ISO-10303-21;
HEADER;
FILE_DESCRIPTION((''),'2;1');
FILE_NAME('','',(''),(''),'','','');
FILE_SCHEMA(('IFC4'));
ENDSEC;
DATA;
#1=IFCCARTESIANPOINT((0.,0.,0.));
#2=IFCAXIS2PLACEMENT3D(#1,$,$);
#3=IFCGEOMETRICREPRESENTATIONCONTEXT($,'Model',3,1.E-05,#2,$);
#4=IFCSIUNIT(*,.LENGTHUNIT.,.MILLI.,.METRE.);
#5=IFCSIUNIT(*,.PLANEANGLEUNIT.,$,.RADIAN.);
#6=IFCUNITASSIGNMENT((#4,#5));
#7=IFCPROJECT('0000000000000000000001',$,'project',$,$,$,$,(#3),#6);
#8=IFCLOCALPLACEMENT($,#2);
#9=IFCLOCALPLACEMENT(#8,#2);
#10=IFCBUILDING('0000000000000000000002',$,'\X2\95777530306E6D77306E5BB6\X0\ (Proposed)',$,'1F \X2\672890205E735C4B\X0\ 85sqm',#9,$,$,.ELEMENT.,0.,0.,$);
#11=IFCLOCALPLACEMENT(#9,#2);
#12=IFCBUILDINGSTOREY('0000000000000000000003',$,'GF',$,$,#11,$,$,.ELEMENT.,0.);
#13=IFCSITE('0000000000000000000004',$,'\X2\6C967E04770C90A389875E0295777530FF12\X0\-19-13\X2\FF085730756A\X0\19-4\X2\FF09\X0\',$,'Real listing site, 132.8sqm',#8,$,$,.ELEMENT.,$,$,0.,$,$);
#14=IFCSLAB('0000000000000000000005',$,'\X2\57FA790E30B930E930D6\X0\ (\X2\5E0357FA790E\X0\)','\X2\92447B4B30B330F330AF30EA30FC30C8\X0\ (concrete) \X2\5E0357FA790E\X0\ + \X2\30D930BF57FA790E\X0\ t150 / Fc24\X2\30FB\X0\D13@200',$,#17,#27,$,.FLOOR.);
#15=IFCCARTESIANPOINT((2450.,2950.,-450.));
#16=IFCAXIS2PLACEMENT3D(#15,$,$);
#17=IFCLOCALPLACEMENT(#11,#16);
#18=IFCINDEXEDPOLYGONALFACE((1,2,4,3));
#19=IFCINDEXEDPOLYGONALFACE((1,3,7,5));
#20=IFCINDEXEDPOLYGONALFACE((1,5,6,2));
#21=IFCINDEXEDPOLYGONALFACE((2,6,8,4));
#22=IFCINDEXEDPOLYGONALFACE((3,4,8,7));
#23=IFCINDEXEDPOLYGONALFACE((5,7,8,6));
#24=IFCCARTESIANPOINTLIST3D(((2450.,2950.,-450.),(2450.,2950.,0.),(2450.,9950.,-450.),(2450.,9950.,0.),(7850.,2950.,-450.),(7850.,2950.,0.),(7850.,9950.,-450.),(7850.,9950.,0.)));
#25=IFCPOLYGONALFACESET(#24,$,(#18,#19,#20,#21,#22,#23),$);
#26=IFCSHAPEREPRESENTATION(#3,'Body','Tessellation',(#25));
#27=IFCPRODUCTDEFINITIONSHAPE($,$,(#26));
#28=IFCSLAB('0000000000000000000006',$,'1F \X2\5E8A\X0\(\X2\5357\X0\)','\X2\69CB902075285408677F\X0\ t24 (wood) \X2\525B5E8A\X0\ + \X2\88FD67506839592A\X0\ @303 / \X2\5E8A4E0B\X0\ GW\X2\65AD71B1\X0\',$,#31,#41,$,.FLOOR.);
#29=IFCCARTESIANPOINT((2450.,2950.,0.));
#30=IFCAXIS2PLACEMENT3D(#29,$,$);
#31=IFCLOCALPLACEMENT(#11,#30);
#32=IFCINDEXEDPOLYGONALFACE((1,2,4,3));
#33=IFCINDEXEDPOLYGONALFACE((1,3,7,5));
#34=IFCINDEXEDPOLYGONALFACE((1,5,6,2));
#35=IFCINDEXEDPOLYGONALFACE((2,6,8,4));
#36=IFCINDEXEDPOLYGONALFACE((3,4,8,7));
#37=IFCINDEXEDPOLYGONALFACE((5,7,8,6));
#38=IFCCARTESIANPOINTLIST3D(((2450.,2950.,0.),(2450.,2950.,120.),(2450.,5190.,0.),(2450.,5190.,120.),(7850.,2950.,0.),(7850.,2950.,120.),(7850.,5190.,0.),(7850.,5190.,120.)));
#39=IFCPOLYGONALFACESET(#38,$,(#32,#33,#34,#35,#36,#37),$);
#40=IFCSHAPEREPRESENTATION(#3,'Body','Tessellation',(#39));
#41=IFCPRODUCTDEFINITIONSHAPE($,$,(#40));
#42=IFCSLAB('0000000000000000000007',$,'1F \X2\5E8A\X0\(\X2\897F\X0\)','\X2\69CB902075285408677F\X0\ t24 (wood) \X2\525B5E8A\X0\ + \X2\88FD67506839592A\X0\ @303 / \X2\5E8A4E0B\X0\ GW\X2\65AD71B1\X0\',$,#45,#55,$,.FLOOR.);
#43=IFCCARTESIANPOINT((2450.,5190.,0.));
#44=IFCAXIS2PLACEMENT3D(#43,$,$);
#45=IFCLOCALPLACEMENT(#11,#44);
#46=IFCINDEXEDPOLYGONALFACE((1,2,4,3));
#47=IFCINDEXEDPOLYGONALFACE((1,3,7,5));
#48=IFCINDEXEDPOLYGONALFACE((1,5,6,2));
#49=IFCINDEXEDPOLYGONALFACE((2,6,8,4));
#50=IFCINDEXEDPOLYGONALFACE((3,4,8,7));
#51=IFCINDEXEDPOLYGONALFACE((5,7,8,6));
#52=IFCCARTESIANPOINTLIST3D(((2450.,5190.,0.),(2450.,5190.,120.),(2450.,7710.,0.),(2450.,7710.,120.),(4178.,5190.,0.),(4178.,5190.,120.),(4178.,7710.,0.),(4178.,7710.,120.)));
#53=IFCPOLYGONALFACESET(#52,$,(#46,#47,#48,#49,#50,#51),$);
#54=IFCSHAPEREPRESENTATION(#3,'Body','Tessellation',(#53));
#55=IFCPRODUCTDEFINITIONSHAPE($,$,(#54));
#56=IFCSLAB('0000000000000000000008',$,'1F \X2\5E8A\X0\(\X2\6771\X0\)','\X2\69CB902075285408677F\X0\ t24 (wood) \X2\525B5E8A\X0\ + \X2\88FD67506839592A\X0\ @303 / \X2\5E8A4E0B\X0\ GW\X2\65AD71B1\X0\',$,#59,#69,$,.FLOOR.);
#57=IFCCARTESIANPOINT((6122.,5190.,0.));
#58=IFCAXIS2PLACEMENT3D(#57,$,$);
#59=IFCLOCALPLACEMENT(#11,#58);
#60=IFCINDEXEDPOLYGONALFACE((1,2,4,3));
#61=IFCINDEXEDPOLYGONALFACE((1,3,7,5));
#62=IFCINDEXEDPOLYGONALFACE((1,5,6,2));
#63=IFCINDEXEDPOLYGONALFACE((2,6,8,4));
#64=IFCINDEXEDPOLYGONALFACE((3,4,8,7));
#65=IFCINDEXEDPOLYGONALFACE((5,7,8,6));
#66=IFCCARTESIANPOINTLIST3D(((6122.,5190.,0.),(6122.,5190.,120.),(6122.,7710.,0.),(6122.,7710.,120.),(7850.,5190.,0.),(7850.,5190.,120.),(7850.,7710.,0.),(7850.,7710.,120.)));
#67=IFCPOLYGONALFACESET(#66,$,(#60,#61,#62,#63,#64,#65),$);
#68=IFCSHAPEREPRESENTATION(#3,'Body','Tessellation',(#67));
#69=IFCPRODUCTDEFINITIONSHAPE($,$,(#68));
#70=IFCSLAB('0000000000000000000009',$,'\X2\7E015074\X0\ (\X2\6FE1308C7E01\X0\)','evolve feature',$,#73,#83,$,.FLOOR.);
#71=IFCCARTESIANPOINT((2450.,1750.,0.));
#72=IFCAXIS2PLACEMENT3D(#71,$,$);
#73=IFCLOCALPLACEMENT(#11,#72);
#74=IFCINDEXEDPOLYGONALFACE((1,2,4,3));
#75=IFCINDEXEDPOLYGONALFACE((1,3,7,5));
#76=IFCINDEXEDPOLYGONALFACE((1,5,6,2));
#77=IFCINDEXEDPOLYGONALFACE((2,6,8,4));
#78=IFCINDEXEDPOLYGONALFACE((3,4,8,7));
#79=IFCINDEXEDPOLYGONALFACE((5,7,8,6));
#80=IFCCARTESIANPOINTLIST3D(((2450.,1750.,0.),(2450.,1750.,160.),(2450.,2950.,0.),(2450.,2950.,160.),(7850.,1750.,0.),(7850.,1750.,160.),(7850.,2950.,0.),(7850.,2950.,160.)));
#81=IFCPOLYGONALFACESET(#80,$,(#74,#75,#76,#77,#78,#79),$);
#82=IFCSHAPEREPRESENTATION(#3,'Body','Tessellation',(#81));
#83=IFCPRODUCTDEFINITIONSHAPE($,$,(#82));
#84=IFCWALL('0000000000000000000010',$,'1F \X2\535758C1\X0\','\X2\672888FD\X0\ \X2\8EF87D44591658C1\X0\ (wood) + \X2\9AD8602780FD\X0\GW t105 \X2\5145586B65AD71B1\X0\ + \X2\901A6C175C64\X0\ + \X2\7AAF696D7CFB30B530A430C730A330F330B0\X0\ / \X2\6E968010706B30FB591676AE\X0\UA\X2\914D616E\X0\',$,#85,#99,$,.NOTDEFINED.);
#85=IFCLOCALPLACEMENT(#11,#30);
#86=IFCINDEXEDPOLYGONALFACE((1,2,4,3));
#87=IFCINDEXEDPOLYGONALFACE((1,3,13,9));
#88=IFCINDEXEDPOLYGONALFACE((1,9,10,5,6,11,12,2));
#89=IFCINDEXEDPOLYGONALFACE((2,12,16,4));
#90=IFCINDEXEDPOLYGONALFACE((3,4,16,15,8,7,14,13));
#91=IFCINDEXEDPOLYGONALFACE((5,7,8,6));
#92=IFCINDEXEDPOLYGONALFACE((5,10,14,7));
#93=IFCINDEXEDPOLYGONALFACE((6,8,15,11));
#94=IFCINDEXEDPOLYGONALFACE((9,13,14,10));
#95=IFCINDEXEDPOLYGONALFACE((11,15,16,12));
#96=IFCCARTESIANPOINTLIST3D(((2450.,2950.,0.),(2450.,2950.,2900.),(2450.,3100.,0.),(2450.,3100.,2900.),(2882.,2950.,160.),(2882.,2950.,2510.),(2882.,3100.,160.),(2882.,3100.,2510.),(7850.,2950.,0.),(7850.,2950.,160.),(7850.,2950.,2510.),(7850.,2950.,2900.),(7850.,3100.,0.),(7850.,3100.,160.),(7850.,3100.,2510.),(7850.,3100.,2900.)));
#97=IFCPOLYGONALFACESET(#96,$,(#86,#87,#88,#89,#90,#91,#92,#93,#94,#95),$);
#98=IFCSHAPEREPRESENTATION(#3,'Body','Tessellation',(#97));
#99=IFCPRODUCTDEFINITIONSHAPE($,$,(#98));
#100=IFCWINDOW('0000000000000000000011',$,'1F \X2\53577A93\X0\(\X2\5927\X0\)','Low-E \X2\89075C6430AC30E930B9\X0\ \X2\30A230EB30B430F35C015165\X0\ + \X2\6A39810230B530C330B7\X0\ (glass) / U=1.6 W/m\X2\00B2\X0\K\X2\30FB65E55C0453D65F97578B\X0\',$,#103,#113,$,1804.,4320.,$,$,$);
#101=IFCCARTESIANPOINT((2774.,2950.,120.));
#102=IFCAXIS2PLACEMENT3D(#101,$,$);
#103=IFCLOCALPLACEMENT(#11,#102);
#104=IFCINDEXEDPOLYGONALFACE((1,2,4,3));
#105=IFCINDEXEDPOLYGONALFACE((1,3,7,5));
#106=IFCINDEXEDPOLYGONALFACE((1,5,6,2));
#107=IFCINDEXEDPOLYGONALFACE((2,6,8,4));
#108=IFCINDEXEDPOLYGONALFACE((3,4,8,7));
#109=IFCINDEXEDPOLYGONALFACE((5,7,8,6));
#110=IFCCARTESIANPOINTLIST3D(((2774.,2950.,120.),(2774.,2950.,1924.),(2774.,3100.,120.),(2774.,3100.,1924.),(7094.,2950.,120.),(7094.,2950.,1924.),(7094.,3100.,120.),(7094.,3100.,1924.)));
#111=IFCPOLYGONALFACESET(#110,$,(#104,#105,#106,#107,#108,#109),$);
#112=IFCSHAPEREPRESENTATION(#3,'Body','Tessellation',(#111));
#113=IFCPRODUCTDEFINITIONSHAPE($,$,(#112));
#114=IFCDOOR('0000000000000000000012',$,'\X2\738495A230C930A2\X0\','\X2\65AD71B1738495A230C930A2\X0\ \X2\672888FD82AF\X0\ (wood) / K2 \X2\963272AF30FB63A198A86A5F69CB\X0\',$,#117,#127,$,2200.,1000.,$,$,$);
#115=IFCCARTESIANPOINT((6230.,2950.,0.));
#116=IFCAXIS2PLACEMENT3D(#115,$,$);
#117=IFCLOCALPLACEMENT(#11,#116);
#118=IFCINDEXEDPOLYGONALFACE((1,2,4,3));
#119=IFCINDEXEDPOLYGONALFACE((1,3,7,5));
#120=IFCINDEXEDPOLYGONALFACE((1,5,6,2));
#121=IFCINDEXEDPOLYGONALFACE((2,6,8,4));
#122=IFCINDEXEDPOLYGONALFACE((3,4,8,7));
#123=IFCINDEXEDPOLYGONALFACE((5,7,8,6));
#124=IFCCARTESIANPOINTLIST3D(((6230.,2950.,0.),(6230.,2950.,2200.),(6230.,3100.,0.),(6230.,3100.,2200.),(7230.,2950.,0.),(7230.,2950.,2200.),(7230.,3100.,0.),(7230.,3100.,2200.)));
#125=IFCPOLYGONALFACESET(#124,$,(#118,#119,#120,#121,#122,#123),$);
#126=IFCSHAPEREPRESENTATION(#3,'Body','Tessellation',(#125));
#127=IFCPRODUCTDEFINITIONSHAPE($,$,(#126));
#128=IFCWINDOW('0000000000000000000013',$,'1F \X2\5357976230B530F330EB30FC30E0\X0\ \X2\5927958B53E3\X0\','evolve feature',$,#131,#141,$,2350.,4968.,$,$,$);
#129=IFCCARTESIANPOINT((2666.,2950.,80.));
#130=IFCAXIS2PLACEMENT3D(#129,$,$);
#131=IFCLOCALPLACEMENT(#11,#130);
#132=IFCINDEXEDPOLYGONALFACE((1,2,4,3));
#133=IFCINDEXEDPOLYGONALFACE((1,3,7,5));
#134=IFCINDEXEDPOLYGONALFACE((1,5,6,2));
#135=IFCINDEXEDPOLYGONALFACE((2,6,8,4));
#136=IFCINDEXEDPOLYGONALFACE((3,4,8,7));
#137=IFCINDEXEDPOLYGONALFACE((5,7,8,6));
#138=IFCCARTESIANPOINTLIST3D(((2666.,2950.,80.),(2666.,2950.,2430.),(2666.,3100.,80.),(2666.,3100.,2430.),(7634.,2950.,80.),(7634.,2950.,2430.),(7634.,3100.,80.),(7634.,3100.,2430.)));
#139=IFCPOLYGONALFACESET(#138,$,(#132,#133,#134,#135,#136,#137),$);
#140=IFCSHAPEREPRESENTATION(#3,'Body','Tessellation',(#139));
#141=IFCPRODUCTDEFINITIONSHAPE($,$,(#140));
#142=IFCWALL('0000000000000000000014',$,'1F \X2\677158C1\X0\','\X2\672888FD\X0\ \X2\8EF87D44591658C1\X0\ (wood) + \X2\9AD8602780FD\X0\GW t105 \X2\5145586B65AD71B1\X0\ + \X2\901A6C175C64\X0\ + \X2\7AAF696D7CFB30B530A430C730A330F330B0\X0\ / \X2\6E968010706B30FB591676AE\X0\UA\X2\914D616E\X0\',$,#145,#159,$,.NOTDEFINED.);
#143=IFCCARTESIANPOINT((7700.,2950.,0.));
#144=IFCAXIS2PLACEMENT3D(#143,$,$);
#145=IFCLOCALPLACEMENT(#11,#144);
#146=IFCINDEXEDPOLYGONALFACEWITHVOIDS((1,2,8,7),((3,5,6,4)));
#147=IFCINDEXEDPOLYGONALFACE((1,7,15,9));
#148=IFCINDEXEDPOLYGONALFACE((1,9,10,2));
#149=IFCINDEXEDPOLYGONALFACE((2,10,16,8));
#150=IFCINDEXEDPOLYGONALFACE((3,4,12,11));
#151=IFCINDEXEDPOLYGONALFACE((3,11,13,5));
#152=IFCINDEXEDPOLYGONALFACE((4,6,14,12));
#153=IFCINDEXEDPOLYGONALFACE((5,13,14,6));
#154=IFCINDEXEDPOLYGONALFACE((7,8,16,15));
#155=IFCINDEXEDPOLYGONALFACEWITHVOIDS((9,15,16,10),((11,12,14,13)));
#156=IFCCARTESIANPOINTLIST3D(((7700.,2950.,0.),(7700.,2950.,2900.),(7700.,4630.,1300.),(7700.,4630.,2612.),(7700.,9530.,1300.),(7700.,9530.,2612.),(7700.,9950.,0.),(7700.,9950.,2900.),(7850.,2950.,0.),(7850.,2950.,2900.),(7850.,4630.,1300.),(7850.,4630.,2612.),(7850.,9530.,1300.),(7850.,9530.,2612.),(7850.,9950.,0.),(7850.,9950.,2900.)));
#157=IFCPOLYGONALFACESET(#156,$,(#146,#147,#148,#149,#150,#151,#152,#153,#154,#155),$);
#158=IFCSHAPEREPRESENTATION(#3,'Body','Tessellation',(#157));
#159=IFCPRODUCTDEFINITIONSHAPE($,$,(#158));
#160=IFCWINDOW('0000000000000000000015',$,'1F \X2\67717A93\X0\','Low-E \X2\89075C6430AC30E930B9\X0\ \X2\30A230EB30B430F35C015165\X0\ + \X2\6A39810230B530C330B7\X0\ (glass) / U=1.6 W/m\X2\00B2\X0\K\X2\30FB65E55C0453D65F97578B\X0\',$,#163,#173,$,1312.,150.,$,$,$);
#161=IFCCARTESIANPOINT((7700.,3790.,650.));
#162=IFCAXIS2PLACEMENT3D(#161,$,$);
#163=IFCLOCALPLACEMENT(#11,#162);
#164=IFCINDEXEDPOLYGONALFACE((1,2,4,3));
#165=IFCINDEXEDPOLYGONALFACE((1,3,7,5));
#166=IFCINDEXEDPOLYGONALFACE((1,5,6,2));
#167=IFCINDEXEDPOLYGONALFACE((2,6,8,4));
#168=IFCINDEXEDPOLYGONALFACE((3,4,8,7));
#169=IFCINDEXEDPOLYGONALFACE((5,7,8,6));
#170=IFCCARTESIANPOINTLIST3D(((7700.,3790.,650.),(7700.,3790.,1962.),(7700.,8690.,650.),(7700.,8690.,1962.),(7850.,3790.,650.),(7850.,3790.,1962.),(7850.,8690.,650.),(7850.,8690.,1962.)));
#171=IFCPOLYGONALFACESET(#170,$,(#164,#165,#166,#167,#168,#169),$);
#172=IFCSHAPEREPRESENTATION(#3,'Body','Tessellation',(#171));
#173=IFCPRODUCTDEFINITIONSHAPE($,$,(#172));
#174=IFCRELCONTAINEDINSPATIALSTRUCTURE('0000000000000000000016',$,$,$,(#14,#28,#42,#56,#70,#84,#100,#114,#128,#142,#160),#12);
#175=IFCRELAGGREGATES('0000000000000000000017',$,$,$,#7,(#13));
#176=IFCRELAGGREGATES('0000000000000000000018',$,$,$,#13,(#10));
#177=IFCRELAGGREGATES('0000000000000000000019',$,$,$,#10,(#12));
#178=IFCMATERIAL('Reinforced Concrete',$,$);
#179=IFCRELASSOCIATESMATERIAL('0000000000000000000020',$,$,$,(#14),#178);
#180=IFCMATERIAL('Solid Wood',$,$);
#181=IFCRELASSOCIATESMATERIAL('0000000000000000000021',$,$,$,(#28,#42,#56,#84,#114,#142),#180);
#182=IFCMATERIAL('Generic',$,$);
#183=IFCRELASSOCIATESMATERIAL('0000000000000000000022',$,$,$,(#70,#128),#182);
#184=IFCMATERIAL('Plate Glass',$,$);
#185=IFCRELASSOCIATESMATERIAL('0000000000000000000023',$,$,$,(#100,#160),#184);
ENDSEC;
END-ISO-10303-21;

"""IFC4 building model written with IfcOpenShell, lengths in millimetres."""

from ifc_helpers import new_model, si_unit, frame, frame_2d, origin, place, context, project, spatial, rectangle, extrude, material, element, fill, save


model = new_model("IFC4")

# Units and contexts
model_context = context("Model", 3, precision=1e-05, world=origin())
ifc_project = project(units=[si_unit("LENGTHUNIT", "METRE", prefix="MILLI"), si_unit("PLANEANGLEUNIT", "RADIAN")], contexts=[model_context])

# Site, building, storey
site_placement = place(None, origin())
site = spatial("IfcSite", under=ifc_project, at=site_placement, Name="沖縄県那覇市長田２-19-13（地番19-4）", ObjectType="Real listing site, 132.8sqm", CompositionType="ELEMENT", RefElevation=0.0)
building_placement = place(site_placement, origin())
building = spatial("IfcBuilding", under=site, at=building_placement, Name="長田の海の家 (Proposed)", ObjectType="1F 木造平屋 85sqm", CompositionType="ELEMENT", ElevationOfRefHeight=0.0, ElevationOfTerrain=0.0)
storey_placement = place(building_placement, origin())
storey = spatial("IfcBuildingStorey", under=building, at=storey_placement, Name="GF", CompositionType="ELEMENT", Elevation=0.0)

# Slabs
ifc_material_1 = material(Name="Reinforced Concrete")
slab_1_placement = place(storey_placement, frame((2450.0, 2950.0, -450.0)))
element("IfcSlab", 1, at=slab_1_placement, inside=storey, material=ifc_material_1, Name="基礎スラブ (布基礎)", Description="鉄筋コンクリート (concrete) 布基礎 + ベタ基礎 t150 / Fc24・D13@200", PredefinedType="FLOOR", context=model_context, shape_type="SweptSolid", body=[
    extrude(rectangle(XDim=5400.0, YDim=7000.0, at=frame_2d((2700.0, 3500.0))), frame((2450.0, 2950.0, -450.0)), (0.0, 0.0, 1.0), 450.0),
])
ifc_material_2 = material(Name="Solid Wood")
slab_2_placement = place(storey_placement, frame((2450.0, 2950.0, 0.0)))
element("IfcSlab", 2, at=slab_2_placement, inside=storey, material=ifc_material_2, Name="1F 床(南)", Description="構造用合板 t24 (wood) 剛床 + 製材根太 @303 / 床下 GW断熱", PredefinedType="FLOOR", context=model_context, shape_type="SweptSolid", body=[
    extrude(rectangle(XDim=5400.0, YDim=2240.0, at=frame_2d((2700.0, 1120.0))), frame((2450.0, 2950.0, 0.0)), (0.0, 0.0, 1.0), 120.0),
])
slab_3_placement = place(storey_placement, frame((2450.0, 5190.0, 0.0)))
element("IfcSlab", 3, at=slab_3_placement, inside=storey, material=ifc_material_2, Name="1F 床(西)", Description="構造用合板 t24 (wood) 剛床 + 製材根太 @303 / 床下 GW断熱", PredefinedType="FLOOR", context=model_context, shape_type="SweptSolid", body=[
    extrude(rectangle(XDim=1728.0, YDim=2520.0, at=frame_2d((864.0, 1260.0))), frame((2450.0, 5190.0, 0.0)), (0.0, 0.0, 1.0), 120.0),
])
slab_4_placement = place(storey_placement, frame((6122.0, 5190.0, 0.0)))
element("IfcSlab", 4, at=slab_4_placement, inside=storey, material=ifc_material_2, Name="1F 床(東)", Description="構造用合板 t24 (wood) 剛床 + 製材根太 @303 / 床下 GW断熱", PredefinedType="FLOOR", context=model_context, shape_type="SweptSolid", body=[
    extrude(rectangle(XDim=1728.0, YDim=2520.0, at=frame_2d((864.0, 1260.0))), frame((6122.0, 5190.0, 0.0)), (0.0, 0.0, 1.0), 120.0),
])
ifc_material_3 = material(Name="Generic")
slab_5_placement = place(storey_placement, frame((2450.0, 1750.0, 0.0)))
element("IfcSlab", 5, at=slab_5_placement, inside=storey, material=ifc_material_3, Name="縁側 (濡れ縁)", Description="evolve feature", PredefinedType="FLOOR", context=model_context, shape_type="SweptSolid", body=[
    extrude(rectangle(XDim=5400.0, YDim=1200.0, at=frame_2d((2700.0, 600.0))), frame((2450.0, 1750.0, 0.0)), (0.0, 0.0, 1.0), 160.0),
])

# Wall, openings, windows, door
wall_1_placement = place(storey_placement, frame((2450.0, 2950.0, 0.0)))
wall_1 = element("IfcWall", 6, at=wall_1_placement, inside=storey, material=ifc_material_2, Name="1F 南壁", Description="木製 軸組外壁 (wood) + 高性能GW t105 充填断熱 + 通気層 + 窯業系サイディング / 準耐火・外皮UA配慮", PredefinedType="NOTDEFINED", context=model_context, shape_type="SweptSolid", body=[
    extrude(rectangle(XDim=5400.0, YDim=150.0, at=frame_2d((2700.0, 75.0))), frame((2450.0, 2950.0, 0.0)), (0.0, 0.0, 1.0), 2900.0),
])
opening_1_placement = place(storey_placement, frame((2774.0, 2950.0, 120.0)))
opening_1 = element("IfcOpeningElement", 7, at=opening_1_placement, cuts=wall_1, PredefinedType="NOTDEFINED", context=model_context, shape_type="SweptSolid", body=[
    extrude(rectangle(XDim=4320.0, YDim=150.0, at=frame_2d((2160.0, 75.0))), frame((2774.0, 2950.0, 120.0)), (0.0, 0.0, 1.0), 1804.0),
])
opening_2_placement = place(storey_placement, frame((6230.0, 2950.0, 0.0)))
opening_2 = element("IfcOpeningElement", 8, at=opening_2_placement, cuts=wall_1, PredefinedType="NOTDEFINED", context=model_context, shape_type="SweptSolid", body=[
    extrude(rectangle(XDim=1000.0, YDim=150.0, at=frame_2d((500.0, 75.0))), frame((6230.0, 2950.0, 0.0)), (0.0, 0.0, 1.0), 2200.0),
])
opening_3_placement = place(storey_placement, frame((2666.0, 2950.0, 80.0)))
opening_3 = element("IfcOpeningElement", 9, at=opening_3_placement, cuts=wall_1, PredefinedType="NOTDEFINED", context=model_context, shape_type="SweptSolid", body=[
    extrude(rectangle(XDim=4968.0, YDim=150.0, at=frame_2d((2484.0, 75.0))), frame((2666.0, 2950.0, 80.0)), (0.0, 0.0, 1.0), 2350.0),
])
ifc_material_4 = material(Name="Plate Glass")
window_1_placement = place(storey_placement, frame((2774.0, 2950.0, 120.0)))
window_1 = element("IfcWindow", 10, at=window_1_placement, inside=storey, material=ifc_material_4, Name="1F 南窓(大)", Description="Low-E 複層ガラス アルゴン封入 + 樹脂サッシ (glass) / U=1.6 W/m²K・日射取得型", OverallHeight=1804.0, OverallWidth=4320.0, context=model_context, shape_type="SweptSolid", body=[
    extrude(rectangle(XDim=4320.0, YDim=150.0, at=frame_2d((2160.0, 75.0))), frame((2774.0, 2950.0, 120.0)), (0.0, 0.0, 1.0), 1804.0),
])
fill(opening_1, window_1)
door_placement = place(storey_placement, frame((6230.0, 2950.0, 0.0)))
door = element("IfcDoor", 11, at=door_placement, inside=storey, material=ifc_material_2, Name="玄関ドア", Description="断熱玄関ドア 木製芯 (wood) / K2 防犯・採風機構", OverallHeight=2200.0, OverallWidth=1000.0, context=model_context, shape_type="SweptSolid", body=[
    extrude(rectangle(XDim=1000.0, YDim=150.0, at=frame_2d((500.0, 75.0))), frame((6230.0, 2950.0, 0.0)), (0.0, 0.0, 1.0), 2200.0),
])
fill(opening_2, door)
window_2_placement = place(storey_placement, frame((2666.0, 2950.0, 80.0)))
window_2 = element("IfcWindow", 12, at=window_2_placement, inside=storey, material=ifc_material_3, Name="1F 南面サンルーム 大開口", Description="evolve feature", OverallHeight=2350.0, OverallWidth=4968.0, context=model_context, shape_type="SweptSolid", body=[
    extrude(rectangle(XDim=4968.0, YDim=150.0, at=frame_2d((2484.0, 75.0))), frame((2666.0, 2950.0, 80.0)), (0.0, 0.0, 1.0), 2350.0),
])
fill(opening_3, window_2)

# Wall, opening, window
wall_2_placement = place(storey_placement, frame((7700.0, 2950.0, 0.0)))
wall_2 = element("IfcWall", 13, at=wall_2_placement, inside=storey, material=ifc_material_2, Name="1F 東壁", Description="木製 軸組外壁 (wood) + 高性能GW t105 充填断熱 + 通気層 + 窯業系サイディング / 準耐火・外皮UA配慮", PredefinedType="NOTDEFINED", context=model_context, shape_type="SweptSolid", body=[
    extrude(rectangle(XDim=150.0, YDim=7000.0, at=frame_2d((75.0, 3500.0))), frame((7700.0, 2950.0, 0.0)), (0.0, 0.0, 1.0), 2900.0),
])
opening_4_placement = place(storey_placement, frame((7700.0, 3790.0, 650.0)))
opening_4 = element("IfcOpeningElement", 14, at=opening_4_placement, cuts=wall_2, PredefinedType="NOTDEFINED", context=model_context, shape_type="SweptSolid", body=[
    extrude(rectangle(XDim=150.0, YDim=4900.0, at=frame_2d((75.0, 2450.0))), frame((7700.0, 3790.0, 650.0)), (0.0, 0.0, 1.0), 1312.0),
])
window_3_placement = place(storey_placement, frame((7700.0, 3790.0, 650.0)))
window_3 = element("IfcWindow", 15, at=window_3_placement, inside=storey, material=ifc_material_4, Name="1F 東窓", Description="Low-E 複層ガラス アルゴン封入 + 樹脂サッシ (glass) / U=1.6 W/m²K・日射取得型", OverallHeight=1312.0, OverallWidth=150.0, context=model_context, shape_type="SweptSolid", body=[
    extrude(rectangle(XDim=150.0, YDim=4900.0, at=frame_2d((75.0, 2450.0))), frame((7700.0, 3790.0, 650.0)), (0.0, 0.0, 1.0), 1312.0),
])
fill(opening_4, window_3)

save(model, "model.ifc")
